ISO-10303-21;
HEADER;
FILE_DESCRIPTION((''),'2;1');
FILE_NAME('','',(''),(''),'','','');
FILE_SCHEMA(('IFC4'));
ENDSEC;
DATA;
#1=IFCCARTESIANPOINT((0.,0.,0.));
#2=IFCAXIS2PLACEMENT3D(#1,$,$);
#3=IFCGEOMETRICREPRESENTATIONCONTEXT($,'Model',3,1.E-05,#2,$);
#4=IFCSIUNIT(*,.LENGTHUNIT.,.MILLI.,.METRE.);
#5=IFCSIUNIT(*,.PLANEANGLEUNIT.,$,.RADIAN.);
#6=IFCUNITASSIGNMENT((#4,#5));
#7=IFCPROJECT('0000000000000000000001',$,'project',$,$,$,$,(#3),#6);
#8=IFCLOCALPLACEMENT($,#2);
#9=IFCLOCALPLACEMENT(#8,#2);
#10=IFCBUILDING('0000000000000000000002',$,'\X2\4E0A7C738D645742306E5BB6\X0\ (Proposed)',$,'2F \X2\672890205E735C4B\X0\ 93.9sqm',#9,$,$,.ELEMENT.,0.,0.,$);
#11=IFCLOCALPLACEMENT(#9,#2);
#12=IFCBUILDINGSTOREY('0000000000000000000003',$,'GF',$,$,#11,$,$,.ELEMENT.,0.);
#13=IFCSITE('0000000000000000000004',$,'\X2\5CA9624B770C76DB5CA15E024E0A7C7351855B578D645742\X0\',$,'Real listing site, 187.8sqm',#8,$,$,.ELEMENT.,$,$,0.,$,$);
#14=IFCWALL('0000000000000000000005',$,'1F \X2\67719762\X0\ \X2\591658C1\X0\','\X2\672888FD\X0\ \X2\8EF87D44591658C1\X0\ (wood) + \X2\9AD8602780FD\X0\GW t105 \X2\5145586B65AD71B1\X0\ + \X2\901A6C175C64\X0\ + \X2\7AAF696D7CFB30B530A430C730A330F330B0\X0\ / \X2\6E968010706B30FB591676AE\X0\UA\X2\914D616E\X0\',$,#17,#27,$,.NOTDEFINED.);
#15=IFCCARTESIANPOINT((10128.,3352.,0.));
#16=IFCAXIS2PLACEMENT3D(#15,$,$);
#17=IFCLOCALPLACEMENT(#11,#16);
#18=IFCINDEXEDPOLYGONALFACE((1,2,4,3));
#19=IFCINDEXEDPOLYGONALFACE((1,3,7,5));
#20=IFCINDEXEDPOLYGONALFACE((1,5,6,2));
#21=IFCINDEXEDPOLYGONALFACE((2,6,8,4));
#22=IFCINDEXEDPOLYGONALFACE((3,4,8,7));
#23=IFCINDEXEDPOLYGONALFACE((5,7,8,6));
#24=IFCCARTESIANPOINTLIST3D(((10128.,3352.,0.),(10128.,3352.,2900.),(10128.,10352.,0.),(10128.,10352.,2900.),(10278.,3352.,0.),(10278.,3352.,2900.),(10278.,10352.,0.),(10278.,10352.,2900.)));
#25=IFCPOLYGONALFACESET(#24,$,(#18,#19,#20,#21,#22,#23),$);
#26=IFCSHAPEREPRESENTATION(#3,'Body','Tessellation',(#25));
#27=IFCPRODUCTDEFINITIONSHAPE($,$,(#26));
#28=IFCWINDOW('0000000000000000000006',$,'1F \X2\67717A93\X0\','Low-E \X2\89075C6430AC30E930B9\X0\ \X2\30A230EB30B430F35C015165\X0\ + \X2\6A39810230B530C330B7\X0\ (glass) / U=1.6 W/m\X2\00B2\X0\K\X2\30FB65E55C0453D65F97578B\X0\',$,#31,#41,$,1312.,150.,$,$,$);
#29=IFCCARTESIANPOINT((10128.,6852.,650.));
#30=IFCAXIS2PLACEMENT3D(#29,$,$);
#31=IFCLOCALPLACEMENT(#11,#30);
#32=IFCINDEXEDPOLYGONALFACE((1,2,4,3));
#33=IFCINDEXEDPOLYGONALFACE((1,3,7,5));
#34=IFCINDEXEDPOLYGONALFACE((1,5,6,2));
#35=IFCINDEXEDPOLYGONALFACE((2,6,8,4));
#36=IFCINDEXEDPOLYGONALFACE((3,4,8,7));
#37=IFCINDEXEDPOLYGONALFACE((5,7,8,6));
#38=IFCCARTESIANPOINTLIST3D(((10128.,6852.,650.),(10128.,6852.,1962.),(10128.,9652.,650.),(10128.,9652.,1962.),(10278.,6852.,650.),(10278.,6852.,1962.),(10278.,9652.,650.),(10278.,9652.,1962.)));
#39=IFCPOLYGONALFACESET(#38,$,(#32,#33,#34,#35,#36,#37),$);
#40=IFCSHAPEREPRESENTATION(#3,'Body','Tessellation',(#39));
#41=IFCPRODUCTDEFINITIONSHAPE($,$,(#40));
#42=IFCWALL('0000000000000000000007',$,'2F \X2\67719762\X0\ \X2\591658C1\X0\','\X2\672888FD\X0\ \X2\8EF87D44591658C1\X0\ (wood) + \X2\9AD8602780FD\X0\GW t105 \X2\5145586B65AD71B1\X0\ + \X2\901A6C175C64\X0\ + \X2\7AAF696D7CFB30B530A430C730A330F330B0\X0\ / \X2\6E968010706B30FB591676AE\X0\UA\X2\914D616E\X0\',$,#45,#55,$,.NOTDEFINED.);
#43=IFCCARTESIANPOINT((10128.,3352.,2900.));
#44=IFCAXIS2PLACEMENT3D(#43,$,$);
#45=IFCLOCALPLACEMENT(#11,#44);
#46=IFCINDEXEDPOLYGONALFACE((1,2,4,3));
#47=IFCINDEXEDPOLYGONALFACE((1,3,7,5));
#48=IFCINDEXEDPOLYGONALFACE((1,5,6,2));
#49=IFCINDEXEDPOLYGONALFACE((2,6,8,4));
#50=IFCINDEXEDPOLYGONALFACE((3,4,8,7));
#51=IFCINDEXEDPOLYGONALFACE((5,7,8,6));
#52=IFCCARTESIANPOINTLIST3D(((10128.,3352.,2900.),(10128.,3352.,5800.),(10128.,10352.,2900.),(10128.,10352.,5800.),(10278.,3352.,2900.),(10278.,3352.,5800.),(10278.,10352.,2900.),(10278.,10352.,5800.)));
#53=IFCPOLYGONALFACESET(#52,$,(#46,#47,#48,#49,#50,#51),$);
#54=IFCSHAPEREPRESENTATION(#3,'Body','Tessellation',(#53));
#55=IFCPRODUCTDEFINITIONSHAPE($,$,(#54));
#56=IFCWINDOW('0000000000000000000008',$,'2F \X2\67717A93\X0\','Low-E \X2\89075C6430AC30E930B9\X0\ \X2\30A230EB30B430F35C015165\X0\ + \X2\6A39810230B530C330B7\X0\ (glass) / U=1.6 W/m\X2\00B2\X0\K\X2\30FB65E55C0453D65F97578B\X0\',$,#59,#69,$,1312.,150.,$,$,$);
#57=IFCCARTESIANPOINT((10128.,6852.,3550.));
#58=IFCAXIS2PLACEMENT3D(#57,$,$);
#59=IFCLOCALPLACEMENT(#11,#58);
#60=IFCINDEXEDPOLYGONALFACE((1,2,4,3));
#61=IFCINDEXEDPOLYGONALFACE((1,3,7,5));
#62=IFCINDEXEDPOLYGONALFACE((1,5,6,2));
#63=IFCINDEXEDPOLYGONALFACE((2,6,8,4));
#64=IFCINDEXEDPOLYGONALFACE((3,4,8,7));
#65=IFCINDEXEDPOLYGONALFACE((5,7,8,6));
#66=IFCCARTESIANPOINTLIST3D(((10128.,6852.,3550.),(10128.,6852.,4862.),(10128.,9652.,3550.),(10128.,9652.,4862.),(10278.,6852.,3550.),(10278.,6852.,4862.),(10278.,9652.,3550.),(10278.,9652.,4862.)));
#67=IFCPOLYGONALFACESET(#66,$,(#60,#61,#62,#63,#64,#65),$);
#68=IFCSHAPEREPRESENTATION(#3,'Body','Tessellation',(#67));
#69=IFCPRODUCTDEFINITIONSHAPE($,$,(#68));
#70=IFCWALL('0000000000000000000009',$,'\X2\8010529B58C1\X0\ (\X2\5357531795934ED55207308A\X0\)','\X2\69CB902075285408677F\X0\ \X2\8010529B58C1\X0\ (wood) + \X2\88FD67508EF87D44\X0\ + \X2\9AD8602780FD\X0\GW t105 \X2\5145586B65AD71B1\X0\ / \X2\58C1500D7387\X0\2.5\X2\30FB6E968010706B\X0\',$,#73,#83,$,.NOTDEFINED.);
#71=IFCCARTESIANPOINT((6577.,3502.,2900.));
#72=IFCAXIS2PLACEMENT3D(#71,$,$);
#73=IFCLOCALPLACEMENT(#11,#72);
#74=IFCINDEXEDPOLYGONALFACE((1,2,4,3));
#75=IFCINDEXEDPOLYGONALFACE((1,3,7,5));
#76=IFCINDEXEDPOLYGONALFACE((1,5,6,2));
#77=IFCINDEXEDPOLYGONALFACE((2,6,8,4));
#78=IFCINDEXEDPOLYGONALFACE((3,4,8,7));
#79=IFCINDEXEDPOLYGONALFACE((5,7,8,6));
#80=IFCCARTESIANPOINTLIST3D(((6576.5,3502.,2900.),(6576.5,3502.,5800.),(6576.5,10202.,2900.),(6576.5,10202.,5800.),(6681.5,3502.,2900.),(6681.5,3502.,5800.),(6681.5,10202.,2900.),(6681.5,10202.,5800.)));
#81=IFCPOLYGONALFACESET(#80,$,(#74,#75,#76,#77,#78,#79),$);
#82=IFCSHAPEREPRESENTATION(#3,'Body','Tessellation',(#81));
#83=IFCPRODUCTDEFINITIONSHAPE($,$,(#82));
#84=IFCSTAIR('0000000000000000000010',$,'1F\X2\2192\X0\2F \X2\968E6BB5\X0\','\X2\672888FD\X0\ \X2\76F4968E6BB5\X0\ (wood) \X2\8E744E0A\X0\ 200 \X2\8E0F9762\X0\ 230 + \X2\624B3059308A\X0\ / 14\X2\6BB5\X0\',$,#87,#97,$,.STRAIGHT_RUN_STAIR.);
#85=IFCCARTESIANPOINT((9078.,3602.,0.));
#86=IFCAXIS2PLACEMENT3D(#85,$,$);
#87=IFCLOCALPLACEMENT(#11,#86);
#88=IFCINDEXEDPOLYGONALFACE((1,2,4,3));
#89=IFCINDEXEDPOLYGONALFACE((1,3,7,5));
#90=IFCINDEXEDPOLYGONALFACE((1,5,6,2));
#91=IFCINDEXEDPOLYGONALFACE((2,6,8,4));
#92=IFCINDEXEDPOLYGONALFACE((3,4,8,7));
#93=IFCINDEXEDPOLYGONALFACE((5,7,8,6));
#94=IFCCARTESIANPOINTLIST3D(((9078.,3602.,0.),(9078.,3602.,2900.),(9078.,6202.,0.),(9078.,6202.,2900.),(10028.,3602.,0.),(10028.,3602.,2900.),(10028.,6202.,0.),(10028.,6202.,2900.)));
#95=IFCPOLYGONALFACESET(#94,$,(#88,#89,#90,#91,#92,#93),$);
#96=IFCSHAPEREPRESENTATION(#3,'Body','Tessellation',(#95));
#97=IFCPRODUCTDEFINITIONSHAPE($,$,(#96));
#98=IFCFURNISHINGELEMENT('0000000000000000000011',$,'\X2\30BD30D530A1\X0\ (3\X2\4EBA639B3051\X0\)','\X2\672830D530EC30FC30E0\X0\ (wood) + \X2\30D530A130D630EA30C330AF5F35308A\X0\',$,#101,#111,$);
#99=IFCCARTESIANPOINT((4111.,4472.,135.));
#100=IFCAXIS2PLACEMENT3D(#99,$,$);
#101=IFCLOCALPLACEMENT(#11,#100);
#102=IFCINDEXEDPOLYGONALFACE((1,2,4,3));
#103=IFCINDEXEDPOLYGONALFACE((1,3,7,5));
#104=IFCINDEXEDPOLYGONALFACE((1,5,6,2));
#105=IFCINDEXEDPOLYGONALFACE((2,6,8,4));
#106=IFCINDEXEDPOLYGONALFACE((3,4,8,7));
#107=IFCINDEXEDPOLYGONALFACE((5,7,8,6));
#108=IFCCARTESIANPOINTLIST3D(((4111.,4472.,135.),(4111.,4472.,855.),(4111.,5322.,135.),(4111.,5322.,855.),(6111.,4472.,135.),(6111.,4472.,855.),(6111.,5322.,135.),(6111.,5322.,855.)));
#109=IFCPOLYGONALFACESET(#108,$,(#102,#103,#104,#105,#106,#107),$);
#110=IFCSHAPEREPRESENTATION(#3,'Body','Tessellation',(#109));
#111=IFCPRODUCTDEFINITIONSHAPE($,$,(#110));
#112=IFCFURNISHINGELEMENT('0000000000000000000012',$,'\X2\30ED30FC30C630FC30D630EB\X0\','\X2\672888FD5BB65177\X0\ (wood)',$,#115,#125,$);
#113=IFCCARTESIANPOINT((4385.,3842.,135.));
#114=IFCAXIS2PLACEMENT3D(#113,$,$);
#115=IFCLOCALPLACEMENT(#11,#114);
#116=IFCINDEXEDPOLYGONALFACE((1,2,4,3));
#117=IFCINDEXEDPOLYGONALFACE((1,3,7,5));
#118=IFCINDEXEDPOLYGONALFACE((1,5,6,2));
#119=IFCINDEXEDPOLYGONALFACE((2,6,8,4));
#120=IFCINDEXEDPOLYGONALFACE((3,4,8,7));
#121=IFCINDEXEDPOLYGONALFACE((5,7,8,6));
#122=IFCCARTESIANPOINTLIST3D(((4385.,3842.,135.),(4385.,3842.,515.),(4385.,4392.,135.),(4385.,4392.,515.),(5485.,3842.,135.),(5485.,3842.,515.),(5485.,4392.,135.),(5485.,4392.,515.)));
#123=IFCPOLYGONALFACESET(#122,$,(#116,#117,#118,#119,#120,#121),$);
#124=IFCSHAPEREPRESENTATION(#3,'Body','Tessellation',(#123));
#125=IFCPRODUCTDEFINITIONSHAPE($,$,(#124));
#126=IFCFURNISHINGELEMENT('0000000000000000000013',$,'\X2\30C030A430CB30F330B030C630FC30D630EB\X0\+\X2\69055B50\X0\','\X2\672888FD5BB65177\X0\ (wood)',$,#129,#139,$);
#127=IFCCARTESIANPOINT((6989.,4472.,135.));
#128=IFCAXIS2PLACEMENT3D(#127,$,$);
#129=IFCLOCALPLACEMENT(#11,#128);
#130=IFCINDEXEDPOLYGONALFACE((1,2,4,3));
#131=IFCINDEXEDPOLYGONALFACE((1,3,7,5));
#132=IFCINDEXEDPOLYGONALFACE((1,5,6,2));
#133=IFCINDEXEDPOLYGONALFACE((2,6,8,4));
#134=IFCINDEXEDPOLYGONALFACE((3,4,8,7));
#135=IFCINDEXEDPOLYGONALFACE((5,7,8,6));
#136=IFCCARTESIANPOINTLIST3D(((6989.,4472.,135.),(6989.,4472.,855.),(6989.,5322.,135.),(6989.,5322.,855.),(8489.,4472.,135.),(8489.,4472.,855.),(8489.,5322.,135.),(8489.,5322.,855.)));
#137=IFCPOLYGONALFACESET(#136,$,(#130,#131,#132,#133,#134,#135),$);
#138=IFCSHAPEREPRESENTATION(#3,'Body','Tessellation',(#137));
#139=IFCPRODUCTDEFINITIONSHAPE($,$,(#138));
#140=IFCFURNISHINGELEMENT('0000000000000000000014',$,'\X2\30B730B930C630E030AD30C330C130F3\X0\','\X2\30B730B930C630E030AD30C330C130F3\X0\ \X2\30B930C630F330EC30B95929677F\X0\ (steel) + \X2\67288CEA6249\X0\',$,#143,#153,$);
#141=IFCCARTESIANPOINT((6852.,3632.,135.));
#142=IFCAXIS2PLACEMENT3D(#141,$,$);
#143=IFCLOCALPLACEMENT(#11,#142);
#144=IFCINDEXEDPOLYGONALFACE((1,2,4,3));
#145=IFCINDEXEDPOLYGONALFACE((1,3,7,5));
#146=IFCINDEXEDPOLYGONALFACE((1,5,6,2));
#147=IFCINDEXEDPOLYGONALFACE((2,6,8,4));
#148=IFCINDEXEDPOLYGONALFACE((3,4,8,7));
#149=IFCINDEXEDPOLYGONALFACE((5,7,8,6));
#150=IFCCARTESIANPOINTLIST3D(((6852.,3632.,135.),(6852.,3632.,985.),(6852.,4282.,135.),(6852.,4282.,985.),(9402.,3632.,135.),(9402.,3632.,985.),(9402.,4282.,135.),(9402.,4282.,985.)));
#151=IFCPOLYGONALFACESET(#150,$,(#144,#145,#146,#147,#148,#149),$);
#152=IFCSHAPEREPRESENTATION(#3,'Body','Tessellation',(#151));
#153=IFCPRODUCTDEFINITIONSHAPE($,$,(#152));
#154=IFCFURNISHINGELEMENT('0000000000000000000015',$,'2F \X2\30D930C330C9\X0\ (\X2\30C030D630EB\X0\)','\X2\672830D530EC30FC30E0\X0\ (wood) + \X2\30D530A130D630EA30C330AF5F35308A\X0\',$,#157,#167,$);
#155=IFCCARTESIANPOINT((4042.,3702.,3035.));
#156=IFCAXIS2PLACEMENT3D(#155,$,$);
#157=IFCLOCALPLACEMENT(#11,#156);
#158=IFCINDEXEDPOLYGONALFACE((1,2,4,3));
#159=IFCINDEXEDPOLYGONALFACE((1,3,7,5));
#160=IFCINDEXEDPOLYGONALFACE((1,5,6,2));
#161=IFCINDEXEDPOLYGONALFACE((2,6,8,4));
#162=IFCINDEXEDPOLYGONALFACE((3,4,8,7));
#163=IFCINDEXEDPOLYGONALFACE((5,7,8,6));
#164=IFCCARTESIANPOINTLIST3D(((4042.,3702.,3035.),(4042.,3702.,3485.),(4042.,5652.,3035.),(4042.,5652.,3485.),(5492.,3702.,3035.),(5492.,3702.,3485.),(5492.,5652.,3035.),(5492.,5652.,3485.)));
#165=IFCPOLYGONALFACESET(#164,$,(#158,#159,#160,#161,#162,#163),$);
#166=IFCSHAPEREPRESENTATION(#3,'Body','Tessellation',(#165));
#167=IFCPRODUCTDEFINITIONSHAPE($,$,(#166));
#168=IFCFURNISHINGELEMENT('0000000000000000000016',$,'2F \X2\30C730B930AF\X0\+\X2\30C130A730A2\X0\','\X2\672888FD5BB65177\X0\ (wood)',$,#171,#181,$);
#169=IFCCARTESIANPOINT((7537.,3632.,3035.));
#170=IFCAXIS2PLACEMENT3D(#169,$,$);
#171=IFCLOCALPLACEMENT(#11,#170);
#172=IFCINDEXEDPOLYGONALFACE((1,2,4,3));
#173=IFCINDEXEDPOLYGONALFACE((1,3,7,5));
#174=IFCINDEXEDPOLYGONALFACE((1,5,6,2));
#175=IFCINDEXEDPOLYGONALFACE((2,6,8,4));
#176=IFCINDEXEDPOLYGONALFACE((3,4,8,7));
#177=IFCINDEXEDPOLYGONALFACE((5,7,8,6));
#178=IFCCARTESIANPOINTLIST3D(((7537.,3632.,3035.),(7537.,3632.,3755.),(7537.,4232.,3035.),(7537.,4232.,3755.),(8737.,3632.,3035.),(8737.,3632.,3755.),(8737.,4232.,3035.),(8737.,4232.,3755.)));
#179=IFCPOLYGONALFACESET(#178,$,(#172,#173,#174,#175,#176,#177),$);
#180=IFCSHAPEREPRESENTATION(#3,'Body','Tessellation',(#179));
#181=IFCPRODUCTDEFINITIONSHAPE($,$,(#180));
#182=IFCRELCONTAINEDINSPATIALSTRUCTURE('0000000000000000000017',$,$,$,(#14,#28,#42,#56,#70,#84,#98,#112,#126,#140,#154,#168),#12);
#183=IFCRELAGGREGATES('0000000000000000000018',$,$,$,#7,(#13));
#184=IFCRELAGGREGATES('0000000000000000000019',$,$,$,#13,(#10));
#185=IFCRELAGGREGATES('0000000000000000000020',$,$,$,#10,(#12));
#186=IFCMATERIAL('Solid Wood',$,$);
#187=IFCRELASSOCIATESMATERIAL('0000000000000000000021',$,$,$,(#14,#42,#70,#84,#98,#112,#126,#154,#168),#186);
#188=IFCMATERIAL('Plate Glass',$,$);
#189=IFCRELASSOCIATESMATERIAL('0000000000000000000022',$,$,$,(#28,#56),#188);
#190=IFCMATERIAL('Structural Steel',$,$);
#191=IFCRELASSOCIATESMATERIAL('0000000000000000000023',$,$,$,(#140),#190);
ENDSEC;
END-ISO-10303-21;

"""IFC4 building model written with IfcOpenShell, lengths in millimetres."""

from ifc_helpers import new_model, si_unit, frame, frame_2d, origin, place, context, project, spatial, rectangle, extrude, material, element, fill, save


model = new_model("IFC4")

# Units and contexts
model_context = context("Model", 3, precision=1e-05, world=origin())
ifc_project = project(units=[si_unit("LENGTHUNIT", "METRE", prefix="MILLI"), si_unit("PLANEANGLEUNIT", "RADIAN")], contexts=[model_context])

# Site, building, storey
site_placement = place(None, origin())
site = spatial("IfcSite", under=ifc_project, at=site_placement, Name="岩手県盛岡市上米内字赤坂", ObjectType="Real listing site, 187.8sqm", CompositionType="ELEMENT", RefElevation=0.0)
building_placement = place(site_placement, origin())
building = spatial("IfcBuilding", under=site, at=building_placement, Name="上米赤坂の家 (Proposed)", ObjectType="2F 木造平屋 93.9sqm", CompositionType="ELEMENT", ElevationOfRefHeight=0.0, ElevationOfTerrain=0.0)
storey_placement = place(building_placement, origin())
storey = spatial("IfcBuildingStorey", under=building, at=storey_placement, Name="GF", CompositionType="ELEMENT", Elevation=0.0)

# Wall, opening, window
ifc_material_1 = material(Name="Solid Wood")
wall_1_placement = place(storey_placement, frame((10128.0, 3352.0, 0.0)))
wall_1 = element("IfcWall", 1, at=wall_1_placement, inside=storey, material=ifc_material_1, Name="1F 東面 外壁", Description="木製 軸組外壁 (wood) + 高性能GW t105 充填断熱 + 通気層 + 窯業系サイディング / 準耐火・外皮UA配慮", PredefinedType="NOTDEFINED", context=model_context, shape_type="SweptSolid", body=[
    extrude(rectangle(XDim=150.0, YDim=7000.0, at=frame_2d((75.0, 3500.0))), frame((10128.0, 3352.0, 0.0)), (0.0, 0.0, 1.0), 2900.0),
])
opening_1_placement = place(storey_placement, frame((10128.0, 6852.0, 650.0)))
opening_1 = element("IfcOpeningElement", 2, at=opening_1_placement, cuts=wall_1, PredefinedType="NOTDEFINED", context=model_context, shape_type="SweptSolid", body=[
    extrude(rectangle(XDim=150.0, YDim=2800.0, at=frame_2d((75.0, 1400.0))), frame((10128.0, 6852.0, 650.0)), (0.0, 0.0, 1.0), 1312.0),
])
ifc_material_2 = material(Name="Plate Glass")
window_1_placement = place(storey_placement, frame((10128.0, 6852.0, 650.0)))
window_1 = element("IfcWindow", 3, at=window_1_placement, inside=storey, material=ifc_material_2, Name="1F 東窓", Description="Low-E 複層ガラス アルゴン封入 + 樹脂サッシ (glass) / U=1.6 W/m²K・日射取得型", OverallHeight=1312.0, OverallWidth=150.0, context=model_context, shape_type="SweptSolid", body=[
    extrude(rectangle(XDim=150.0, YDim=2800.0, at=frame_2d((75.0, 1400.0))), frame((10128.0, 6852.0, 650.0)), (0.0, 0.0, 1.0), 1312.0),
])
fill(opening_1, window_1)

# Wall, opening, window
wall_2_placement = place(storey_placement, frame((10128.0, 3352.0, 2900.0)))
wall_2 = element("IfcWall", 4, at=wall_2_placement, inside=storey, material=ifc_material_1, Name="2F 東面 外壁", Description="木製 軸組外壁 (wood) + 高性能GW t105 充填断熱 + 通気層 + 窯業系サイディング / 準耐火・外皮UA配慮", PredefinedType="NOTDEFINED", context=model_context, shape_type="SweptSolid", body=[
    extrude(rectangle(XDim=150.0, YDim=7000.0, at=frame_2d((75.0, 3500.0))), frame((10128.0, 3352.0, 2900.0)), (0.0, 0.0, 1.0), 2900.0),
])
opening_2_placement = place(storey_placement, frame((10128.0, 6852.0, 3550.0)))
opening_2 = element("IfcOpeningElement", 5, at=opening_2_placement, cuts=wall_2, PredefinedType="NOTDEFINED", context=model_context, shape_type="SweptSolid", body=[
    extrude(rectangle(XDim=150.0, YDim=2800.0, at=frame_2d((75.0, 1400.0))), frame((10128.0, 6852.0, 3550.0)), (0.0, 0.0, 1.0), 1312.0),
])
window_2_placement = place(storey_placement, frame((10128.0, 6852.0, 3550.0)))
window_2 = element("IfcWindow", 6, at=window_2_placement, inside=storey, material=ifc_material_2, Name="2F 東窓", Description="Low-E 複層ガラス アルゴン封入 + 樹脂サッシ (glass) / U=1.6 W/m²K・日射取得型", OverallHeight=1312.0, OverallWidth=150.0, context=model_context, shape_type="SweptSolid", body=[
    extrude(rectangle(XDim=150.0, YDim=2800.0, at=frame_2d((75.0, 1400.0))), frame((10128.0, 6852.0, 3550.0)), (0.0, 0.0, 1.0), 1312.0),
])
fill(opening_2, window_2)

# Wall
wall_3_placement = place(storey_placement, frame((6577.0, 3502.0, 2900.0)))
element("IfcWall", 7, at=wall_3_placement, inside=storey, material=ifc_material_1, Name="耐力壁 (南北間仕切り)", Description="構造用合板 耐力壁 (wood) + 製材軸組 + 高性能GW t105 充填断熱 / 壁倍率2.5・準耐火", PredefinedType="NOTDEFINED", context=model_context, shape_type="SweptSolid", body=[
    extrude(rectangle(XDim=105.0, YDim=6700.0, at=frame_2d((52.0, 3350.0))), frame((6577.0, 3502.0, 2900.0)), (0.0, 0.0, 1.0), 2900.0),
])

# Stair
stair_placement = place(storey_placement, frame((9078.0, 3602.0, 0.0)))
element("IfcStair", 8, at=stair_placement, inside=storey, material=ifc_material_1, Name="1F→2F 階段", Description="木製 直階段 (wood) 蹴上 200 踏面 230 + 手すり / 14段", PredefinedType="STRAIGHT_RUN_STAIR", context=model_context, shape_type="SweptSolid", body=[
    extrude(rectangle(XDim=950.0, YDim=2600.0, at=frame_2d((475.0, 1300.0))), frame((9078.0, 3602.0, 0.0)), (0.0, 0.0, 1.0), 2900.0),
])

# Furnishing elements
furnishing_1_placement = place(storey_placement, frame((4111.0, 4472.0, 135.0)))
element("IfcFurnishingElement", 9, at=furnishing_1_placement, inside=storey, material=ifc_material_1, Name="ソファ (3人掛け)", Description="木フレーム (wood) + ファブリック張り", context=model_context, shape_type="SweptSolid", body=[
    extrude(rectangle(XDim=2000.0, YDim=850.0, at=frame_2d((1000.0, 425.0))), frame((4111.0, 4472.0, 135.0)), (0.0, 0.0, 1.0), 720.0),
])
furnishing_2_placement = place(storey_placement, frame((4385.0, 3842.0, 135.0)))
element("IfcFurnishingElement", 10, at=furnishing_2_placement, inside=storey, material=ifc_material_1, Name="ローテーブル", Description="木製家具 (wood)", context=model_context, shape_type="SweptSolid", body=[
    extrude(rectangle(XDim=1100.0, YDim=550.0, at=frame_2d((550.0, 275.0))), frame((4385.0, 3842.0, 135.0)), (0.0, 0.0, 1.0), 380.0),
])
furnishing_3_placement = place(storey_placement, frame((6989.0, 4472.0, 135.0)))
element("IfcFurnishingElement", 11, at=furnishing_3_placement, inside=storey, material=ifc_material_1, Name="ダイニングテーブル+椅子", Description="木製家具 (wood)", context=model_context, shape_type="SweptSolid", body=[
    extrude(rectangle(XDim=1500.0, YDim=850.0, at=frame_2d((750.0, 425.0))), frame((6989.0, 4472.0, 135.0)), (0.0, 0.0, 1.0), 720.0),
])
ifc_material_3 = material(Name="Structural Steel")
furnishing_4_placement = place(storey_placement, frame((6852.0, 3632.0, 135.0)))
element("IfcFurnishingElement", 12, at=furnishing_4_placement, inside=storey, material=ifc_material_3, Name="システムキッチン", Description="システムキッチン ステンレス天板 (steel) + 木質扉", context=model_context, shape_type="SweptSolid", body=[
    extrude(rectangle(XDim=2550.0, YDim=650.0, at=frame_2d((1275.0, 325.0))), frame((6852.0, 3632.0, 135.0)), (0.0, 0.0, 1.0), 850.0),
])
furnishing_5_placement = place(storey_placement, frame((4042.0, 3702.0, 3035.0)))
element("IfcFurnishingElement", 13, at=furnishing_5_placement, inside=storey, material=ifc_material_1, Name="2F ベッド (ダブル)", Description="木フレーム (wood) + ファブリック張り", context=model_context, shape_type="SweptSolid", body=[
    extrude(rectangle(XDim=1450.0, YDim=1950.0, at=frame_2d((725.0, 975.0))), frame((4042.0, 3702.0, 3035.0)), (0.0, 0.0, 1.0), 450.0),
])
furnishing_6_placement = place(storey_placement, frame((7537.0, 3632.0, 3035.0)))
element("IfcFurnishingElement", 14, at=furnishing_6_placement, inside=storey, material=ifc_material_1, Name="2F デスク+チェア", Description="木製家具 (wood)", context=model_context, shape_type="SweptSolid", body=[
    extrude(rectangle(XDim=1200.0, YDim=600.0, at=frame_2d((600.0, 300.0))), frame((7537.0, 3632.0, 3035.0)), (0.0, 0.0, 1.0), 720.0),
])

save(model, "model.ifc")
